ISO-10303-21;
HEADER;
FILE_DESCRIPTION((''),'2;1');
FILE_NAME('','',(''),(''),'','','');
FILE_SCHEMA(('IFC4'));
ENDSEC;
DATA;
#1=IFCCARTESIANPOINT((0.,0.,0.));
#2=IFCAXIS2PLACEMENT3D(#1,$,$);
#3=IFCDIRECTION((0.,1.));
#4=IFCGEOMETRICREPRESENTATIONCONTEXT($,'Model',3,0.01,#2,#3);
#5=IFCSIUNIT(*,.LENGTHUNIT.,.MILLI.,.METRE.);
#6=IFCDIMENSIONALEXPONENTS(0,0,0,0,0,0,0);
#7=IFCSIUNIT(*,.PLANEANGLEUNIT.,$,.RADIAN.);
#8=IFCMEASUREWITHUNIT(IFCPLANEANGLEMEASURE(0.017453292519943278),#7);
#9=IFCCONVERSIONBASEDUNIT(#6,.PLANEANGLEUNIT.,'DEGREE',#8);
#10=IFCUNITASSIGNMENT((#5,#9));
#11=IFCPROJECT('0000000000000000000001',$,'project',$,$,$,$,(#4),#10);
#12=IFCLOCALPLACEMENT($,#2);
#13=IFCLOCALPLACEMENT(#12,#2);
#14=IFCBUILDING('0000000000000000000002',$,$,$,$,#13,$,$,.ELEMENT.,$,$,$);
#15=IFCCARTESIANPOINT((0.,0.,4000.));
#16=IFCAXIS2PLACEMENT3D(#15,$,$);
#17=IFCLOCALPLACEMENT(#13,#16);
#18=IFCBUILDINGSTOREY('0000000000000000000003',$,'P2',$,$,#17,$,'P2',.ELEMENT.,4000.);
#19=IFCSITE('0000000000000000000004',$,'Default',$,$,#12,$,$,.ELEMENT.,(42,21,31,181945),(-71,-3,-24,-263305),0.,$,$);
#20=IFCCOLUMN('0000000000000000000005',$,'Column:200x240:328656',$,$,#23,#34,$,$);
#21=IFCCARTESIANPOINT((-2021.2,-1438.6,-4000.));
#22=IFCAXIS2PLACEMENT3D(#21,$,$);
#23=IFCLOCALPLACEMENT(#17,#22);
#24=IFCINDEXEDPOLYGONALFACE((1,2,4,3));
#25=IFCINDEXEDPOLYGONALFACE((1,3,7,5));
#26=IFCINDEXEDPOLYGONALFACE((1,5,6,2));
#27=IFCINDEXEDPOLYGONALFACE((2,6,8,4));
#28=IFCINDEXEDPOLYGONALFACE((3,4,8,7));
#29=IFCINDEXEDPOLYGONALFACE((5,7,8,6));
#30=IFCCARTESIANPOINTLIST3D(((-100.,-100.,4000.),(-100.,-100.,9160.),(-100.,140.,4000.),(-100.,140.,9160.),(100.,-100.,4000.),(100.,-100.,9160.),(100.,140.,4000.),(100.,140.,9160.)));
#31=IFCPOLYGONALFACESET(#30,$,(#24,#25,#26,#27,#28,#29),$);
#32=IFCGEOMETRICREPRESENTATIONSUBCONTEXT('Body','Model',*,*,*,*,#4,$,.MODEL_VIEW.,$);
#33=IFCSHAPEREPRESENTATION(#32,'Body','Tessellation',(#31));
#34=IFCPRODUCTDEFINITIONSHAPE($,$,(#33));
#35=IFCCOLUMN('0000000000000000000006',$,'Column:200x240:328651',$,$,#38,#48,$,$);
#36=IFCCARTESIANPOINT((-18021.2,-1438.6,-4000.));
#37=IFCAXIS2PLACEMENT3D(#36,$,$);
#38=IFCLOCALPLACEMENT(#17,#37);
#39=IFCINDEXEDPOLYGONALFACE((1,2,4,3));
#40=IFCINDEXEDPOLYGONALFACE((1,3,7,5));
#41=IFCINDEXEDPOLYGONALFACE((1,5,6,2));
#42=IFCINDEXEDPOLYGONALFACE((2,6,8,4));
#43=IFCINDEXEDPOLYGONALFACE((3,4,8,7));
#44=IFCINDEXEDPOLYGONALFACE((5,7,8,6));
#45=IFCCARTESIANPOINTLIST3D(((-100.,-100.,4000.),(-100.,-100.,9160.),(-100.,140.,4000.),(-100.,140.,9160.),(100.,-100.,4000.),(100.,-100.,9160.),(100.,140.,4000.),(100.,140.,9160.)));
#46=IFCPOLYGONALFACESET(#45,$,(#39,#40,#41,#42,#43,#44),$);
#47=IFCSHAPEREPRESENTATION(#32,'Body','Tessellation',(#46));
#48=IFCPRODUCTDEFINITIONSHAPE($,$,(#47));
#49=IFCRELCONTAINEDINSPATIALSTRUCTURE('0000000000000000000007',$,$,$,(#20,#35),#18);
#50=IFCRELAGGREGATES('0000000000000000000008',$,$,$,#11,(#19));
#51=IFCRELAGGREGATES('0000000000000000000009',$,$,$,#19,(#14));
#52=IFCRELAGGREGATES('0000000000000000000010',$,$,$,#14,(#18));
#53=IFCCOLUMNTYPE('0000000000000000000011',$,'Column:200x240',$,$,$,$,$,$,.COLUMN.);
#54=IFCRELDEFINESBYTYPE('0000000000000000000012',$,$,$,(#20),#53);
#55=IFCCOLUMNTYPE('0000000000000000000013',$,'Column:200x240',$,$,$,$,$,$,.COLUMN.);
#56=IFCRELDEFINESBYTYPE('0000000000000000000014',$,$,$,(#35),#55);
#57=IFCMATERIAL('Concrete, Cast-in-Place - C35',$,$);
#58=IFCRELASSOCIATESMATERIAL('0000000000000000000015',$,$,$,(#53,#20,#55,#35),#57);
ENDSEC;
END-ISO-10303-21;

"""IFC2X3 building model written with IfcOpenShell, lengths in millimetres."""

from ifc_helpers import new_model, entity, si_unit, converted_unit, direction, frame, origin, origin_2d_with_axis, place, context, subcontext, project, spatial, rectangle, extrude, source, transform, mapped, material, type_object, type_shapes, element, save


model = new_model("IFC2X3")

# Units and contexts
model_context = context("Model", 3, precision=0.01, world=origin(), true_north=direction((0.0, 1.0)))
body_context = subcontext(model_context, "Body", "Model", "MODEL_VIEW")
ifc_project = project(units=[si_unit("LENGTHUNIT", "METRE", prefix="MILLI"), converted_unit("PLANEANGLEUNIT", "DEGREE", entity("IfcPlaneAngleMeasure", 0.017453292519943278), si_unit("PLANEANGLEUNIT", "RADIAN"), dimensions=[0, 0, 0, 0, 0, 0, 0])], contexts=[model_context])

# Site, building, storey
site_placement = place(None, origin())
site = spatial("IfcSite", under=ifc_project, at=site_placement, Name="Default", CompositionType="ELEMENT", RefLatitude=(42, 21, 31, 181945), RefLongitude=(-71, -3, -24, -263305), RefElevation=0.0)
building_placement = place(site_placement, origin())
building = spatial("IfcBuilding", under=site, at=building_placement, CompositionType="ELEMENT")
storey_placement = place(building_placement, frame((0.0, 0.0, 4000.0)))
storey = spatial("IfcBuildingStorey", under=building, at=storey_placement, Name="P2", LongName="P2", CompositionType="ELEMENT", Elevation=4000.0)

# Columns
ifc_material = material(Name="Concrete, Cast-in-Place - C35")
column_type_1 = type_object("IfcColumnType", Name="Column:200x240", PredefinedType="COLUMN", material=ifc_material)
shared_shape_1 = source(origin(), body_context, "Body", "SweptSolid", [
    extrude(rectangle(XDim=200.0, YDim=240.0, at=origin_2d_with_axis()), frame((0.0, 20.0, 4000.0), z_axis=(0.0, 0.0, 1.0), x_axis=(-1.0, 0.0, 0.0)), (0.0, 0.0, 1.0), 5160.0),
])
type_shapes(column_type_1, [shared_shape_1])
for number, where, name in (
    (1, (-2021.2, -1438.6, -4000.0), "Column:200x240:328656"),
):
    element("IfcColumn", number, at=place(storey_placement, frame(where)), inside=storey, type_object=column_type_1, material=ifc_material, Name=name, context=body_context, shape_type="MappedRepresentation", body=[
        mapped(shared_shape_1, transform((0.0, 0.0, 0.0), scale=1.0)),
    ])
column_type_2 = type_object("IfcColumnType", Name="Column:200x240", PredefinedType="COLUMN", material=ifc_material)
shared_shape_2 = source(origin(), body_context, "Body", "SweptSolid", [
    extrude(rectangle(XDim=200.0, YDim=240.0, at=origin_2d_with_axis()), frame((0.0, 20.0, 4000.0), z_axis=(0.0, 0.0, 1.0), x_axis=(-1.0, 0.0, 0.0)), (0.0, 0.0, 1.0), 5160.0),
])
type_shapes(column_type_2, [shared_shape_2])
column_1_placement = place(storey_placement, frame((-18021.2, -1438.6, -4000.0)))
element("IfcColumn", 2, at=column_1_placement, inside=storey, type_object=column_type_2, material=ifc_material, Name="Column:200x240:328651", context=body_context, shape_type="MappedRepresentation", body=[
    mapped(shared_shape_2, transform((0.0, 0.0, 0.0), scale=1.0)),
])

save(model, "model.ifc")
